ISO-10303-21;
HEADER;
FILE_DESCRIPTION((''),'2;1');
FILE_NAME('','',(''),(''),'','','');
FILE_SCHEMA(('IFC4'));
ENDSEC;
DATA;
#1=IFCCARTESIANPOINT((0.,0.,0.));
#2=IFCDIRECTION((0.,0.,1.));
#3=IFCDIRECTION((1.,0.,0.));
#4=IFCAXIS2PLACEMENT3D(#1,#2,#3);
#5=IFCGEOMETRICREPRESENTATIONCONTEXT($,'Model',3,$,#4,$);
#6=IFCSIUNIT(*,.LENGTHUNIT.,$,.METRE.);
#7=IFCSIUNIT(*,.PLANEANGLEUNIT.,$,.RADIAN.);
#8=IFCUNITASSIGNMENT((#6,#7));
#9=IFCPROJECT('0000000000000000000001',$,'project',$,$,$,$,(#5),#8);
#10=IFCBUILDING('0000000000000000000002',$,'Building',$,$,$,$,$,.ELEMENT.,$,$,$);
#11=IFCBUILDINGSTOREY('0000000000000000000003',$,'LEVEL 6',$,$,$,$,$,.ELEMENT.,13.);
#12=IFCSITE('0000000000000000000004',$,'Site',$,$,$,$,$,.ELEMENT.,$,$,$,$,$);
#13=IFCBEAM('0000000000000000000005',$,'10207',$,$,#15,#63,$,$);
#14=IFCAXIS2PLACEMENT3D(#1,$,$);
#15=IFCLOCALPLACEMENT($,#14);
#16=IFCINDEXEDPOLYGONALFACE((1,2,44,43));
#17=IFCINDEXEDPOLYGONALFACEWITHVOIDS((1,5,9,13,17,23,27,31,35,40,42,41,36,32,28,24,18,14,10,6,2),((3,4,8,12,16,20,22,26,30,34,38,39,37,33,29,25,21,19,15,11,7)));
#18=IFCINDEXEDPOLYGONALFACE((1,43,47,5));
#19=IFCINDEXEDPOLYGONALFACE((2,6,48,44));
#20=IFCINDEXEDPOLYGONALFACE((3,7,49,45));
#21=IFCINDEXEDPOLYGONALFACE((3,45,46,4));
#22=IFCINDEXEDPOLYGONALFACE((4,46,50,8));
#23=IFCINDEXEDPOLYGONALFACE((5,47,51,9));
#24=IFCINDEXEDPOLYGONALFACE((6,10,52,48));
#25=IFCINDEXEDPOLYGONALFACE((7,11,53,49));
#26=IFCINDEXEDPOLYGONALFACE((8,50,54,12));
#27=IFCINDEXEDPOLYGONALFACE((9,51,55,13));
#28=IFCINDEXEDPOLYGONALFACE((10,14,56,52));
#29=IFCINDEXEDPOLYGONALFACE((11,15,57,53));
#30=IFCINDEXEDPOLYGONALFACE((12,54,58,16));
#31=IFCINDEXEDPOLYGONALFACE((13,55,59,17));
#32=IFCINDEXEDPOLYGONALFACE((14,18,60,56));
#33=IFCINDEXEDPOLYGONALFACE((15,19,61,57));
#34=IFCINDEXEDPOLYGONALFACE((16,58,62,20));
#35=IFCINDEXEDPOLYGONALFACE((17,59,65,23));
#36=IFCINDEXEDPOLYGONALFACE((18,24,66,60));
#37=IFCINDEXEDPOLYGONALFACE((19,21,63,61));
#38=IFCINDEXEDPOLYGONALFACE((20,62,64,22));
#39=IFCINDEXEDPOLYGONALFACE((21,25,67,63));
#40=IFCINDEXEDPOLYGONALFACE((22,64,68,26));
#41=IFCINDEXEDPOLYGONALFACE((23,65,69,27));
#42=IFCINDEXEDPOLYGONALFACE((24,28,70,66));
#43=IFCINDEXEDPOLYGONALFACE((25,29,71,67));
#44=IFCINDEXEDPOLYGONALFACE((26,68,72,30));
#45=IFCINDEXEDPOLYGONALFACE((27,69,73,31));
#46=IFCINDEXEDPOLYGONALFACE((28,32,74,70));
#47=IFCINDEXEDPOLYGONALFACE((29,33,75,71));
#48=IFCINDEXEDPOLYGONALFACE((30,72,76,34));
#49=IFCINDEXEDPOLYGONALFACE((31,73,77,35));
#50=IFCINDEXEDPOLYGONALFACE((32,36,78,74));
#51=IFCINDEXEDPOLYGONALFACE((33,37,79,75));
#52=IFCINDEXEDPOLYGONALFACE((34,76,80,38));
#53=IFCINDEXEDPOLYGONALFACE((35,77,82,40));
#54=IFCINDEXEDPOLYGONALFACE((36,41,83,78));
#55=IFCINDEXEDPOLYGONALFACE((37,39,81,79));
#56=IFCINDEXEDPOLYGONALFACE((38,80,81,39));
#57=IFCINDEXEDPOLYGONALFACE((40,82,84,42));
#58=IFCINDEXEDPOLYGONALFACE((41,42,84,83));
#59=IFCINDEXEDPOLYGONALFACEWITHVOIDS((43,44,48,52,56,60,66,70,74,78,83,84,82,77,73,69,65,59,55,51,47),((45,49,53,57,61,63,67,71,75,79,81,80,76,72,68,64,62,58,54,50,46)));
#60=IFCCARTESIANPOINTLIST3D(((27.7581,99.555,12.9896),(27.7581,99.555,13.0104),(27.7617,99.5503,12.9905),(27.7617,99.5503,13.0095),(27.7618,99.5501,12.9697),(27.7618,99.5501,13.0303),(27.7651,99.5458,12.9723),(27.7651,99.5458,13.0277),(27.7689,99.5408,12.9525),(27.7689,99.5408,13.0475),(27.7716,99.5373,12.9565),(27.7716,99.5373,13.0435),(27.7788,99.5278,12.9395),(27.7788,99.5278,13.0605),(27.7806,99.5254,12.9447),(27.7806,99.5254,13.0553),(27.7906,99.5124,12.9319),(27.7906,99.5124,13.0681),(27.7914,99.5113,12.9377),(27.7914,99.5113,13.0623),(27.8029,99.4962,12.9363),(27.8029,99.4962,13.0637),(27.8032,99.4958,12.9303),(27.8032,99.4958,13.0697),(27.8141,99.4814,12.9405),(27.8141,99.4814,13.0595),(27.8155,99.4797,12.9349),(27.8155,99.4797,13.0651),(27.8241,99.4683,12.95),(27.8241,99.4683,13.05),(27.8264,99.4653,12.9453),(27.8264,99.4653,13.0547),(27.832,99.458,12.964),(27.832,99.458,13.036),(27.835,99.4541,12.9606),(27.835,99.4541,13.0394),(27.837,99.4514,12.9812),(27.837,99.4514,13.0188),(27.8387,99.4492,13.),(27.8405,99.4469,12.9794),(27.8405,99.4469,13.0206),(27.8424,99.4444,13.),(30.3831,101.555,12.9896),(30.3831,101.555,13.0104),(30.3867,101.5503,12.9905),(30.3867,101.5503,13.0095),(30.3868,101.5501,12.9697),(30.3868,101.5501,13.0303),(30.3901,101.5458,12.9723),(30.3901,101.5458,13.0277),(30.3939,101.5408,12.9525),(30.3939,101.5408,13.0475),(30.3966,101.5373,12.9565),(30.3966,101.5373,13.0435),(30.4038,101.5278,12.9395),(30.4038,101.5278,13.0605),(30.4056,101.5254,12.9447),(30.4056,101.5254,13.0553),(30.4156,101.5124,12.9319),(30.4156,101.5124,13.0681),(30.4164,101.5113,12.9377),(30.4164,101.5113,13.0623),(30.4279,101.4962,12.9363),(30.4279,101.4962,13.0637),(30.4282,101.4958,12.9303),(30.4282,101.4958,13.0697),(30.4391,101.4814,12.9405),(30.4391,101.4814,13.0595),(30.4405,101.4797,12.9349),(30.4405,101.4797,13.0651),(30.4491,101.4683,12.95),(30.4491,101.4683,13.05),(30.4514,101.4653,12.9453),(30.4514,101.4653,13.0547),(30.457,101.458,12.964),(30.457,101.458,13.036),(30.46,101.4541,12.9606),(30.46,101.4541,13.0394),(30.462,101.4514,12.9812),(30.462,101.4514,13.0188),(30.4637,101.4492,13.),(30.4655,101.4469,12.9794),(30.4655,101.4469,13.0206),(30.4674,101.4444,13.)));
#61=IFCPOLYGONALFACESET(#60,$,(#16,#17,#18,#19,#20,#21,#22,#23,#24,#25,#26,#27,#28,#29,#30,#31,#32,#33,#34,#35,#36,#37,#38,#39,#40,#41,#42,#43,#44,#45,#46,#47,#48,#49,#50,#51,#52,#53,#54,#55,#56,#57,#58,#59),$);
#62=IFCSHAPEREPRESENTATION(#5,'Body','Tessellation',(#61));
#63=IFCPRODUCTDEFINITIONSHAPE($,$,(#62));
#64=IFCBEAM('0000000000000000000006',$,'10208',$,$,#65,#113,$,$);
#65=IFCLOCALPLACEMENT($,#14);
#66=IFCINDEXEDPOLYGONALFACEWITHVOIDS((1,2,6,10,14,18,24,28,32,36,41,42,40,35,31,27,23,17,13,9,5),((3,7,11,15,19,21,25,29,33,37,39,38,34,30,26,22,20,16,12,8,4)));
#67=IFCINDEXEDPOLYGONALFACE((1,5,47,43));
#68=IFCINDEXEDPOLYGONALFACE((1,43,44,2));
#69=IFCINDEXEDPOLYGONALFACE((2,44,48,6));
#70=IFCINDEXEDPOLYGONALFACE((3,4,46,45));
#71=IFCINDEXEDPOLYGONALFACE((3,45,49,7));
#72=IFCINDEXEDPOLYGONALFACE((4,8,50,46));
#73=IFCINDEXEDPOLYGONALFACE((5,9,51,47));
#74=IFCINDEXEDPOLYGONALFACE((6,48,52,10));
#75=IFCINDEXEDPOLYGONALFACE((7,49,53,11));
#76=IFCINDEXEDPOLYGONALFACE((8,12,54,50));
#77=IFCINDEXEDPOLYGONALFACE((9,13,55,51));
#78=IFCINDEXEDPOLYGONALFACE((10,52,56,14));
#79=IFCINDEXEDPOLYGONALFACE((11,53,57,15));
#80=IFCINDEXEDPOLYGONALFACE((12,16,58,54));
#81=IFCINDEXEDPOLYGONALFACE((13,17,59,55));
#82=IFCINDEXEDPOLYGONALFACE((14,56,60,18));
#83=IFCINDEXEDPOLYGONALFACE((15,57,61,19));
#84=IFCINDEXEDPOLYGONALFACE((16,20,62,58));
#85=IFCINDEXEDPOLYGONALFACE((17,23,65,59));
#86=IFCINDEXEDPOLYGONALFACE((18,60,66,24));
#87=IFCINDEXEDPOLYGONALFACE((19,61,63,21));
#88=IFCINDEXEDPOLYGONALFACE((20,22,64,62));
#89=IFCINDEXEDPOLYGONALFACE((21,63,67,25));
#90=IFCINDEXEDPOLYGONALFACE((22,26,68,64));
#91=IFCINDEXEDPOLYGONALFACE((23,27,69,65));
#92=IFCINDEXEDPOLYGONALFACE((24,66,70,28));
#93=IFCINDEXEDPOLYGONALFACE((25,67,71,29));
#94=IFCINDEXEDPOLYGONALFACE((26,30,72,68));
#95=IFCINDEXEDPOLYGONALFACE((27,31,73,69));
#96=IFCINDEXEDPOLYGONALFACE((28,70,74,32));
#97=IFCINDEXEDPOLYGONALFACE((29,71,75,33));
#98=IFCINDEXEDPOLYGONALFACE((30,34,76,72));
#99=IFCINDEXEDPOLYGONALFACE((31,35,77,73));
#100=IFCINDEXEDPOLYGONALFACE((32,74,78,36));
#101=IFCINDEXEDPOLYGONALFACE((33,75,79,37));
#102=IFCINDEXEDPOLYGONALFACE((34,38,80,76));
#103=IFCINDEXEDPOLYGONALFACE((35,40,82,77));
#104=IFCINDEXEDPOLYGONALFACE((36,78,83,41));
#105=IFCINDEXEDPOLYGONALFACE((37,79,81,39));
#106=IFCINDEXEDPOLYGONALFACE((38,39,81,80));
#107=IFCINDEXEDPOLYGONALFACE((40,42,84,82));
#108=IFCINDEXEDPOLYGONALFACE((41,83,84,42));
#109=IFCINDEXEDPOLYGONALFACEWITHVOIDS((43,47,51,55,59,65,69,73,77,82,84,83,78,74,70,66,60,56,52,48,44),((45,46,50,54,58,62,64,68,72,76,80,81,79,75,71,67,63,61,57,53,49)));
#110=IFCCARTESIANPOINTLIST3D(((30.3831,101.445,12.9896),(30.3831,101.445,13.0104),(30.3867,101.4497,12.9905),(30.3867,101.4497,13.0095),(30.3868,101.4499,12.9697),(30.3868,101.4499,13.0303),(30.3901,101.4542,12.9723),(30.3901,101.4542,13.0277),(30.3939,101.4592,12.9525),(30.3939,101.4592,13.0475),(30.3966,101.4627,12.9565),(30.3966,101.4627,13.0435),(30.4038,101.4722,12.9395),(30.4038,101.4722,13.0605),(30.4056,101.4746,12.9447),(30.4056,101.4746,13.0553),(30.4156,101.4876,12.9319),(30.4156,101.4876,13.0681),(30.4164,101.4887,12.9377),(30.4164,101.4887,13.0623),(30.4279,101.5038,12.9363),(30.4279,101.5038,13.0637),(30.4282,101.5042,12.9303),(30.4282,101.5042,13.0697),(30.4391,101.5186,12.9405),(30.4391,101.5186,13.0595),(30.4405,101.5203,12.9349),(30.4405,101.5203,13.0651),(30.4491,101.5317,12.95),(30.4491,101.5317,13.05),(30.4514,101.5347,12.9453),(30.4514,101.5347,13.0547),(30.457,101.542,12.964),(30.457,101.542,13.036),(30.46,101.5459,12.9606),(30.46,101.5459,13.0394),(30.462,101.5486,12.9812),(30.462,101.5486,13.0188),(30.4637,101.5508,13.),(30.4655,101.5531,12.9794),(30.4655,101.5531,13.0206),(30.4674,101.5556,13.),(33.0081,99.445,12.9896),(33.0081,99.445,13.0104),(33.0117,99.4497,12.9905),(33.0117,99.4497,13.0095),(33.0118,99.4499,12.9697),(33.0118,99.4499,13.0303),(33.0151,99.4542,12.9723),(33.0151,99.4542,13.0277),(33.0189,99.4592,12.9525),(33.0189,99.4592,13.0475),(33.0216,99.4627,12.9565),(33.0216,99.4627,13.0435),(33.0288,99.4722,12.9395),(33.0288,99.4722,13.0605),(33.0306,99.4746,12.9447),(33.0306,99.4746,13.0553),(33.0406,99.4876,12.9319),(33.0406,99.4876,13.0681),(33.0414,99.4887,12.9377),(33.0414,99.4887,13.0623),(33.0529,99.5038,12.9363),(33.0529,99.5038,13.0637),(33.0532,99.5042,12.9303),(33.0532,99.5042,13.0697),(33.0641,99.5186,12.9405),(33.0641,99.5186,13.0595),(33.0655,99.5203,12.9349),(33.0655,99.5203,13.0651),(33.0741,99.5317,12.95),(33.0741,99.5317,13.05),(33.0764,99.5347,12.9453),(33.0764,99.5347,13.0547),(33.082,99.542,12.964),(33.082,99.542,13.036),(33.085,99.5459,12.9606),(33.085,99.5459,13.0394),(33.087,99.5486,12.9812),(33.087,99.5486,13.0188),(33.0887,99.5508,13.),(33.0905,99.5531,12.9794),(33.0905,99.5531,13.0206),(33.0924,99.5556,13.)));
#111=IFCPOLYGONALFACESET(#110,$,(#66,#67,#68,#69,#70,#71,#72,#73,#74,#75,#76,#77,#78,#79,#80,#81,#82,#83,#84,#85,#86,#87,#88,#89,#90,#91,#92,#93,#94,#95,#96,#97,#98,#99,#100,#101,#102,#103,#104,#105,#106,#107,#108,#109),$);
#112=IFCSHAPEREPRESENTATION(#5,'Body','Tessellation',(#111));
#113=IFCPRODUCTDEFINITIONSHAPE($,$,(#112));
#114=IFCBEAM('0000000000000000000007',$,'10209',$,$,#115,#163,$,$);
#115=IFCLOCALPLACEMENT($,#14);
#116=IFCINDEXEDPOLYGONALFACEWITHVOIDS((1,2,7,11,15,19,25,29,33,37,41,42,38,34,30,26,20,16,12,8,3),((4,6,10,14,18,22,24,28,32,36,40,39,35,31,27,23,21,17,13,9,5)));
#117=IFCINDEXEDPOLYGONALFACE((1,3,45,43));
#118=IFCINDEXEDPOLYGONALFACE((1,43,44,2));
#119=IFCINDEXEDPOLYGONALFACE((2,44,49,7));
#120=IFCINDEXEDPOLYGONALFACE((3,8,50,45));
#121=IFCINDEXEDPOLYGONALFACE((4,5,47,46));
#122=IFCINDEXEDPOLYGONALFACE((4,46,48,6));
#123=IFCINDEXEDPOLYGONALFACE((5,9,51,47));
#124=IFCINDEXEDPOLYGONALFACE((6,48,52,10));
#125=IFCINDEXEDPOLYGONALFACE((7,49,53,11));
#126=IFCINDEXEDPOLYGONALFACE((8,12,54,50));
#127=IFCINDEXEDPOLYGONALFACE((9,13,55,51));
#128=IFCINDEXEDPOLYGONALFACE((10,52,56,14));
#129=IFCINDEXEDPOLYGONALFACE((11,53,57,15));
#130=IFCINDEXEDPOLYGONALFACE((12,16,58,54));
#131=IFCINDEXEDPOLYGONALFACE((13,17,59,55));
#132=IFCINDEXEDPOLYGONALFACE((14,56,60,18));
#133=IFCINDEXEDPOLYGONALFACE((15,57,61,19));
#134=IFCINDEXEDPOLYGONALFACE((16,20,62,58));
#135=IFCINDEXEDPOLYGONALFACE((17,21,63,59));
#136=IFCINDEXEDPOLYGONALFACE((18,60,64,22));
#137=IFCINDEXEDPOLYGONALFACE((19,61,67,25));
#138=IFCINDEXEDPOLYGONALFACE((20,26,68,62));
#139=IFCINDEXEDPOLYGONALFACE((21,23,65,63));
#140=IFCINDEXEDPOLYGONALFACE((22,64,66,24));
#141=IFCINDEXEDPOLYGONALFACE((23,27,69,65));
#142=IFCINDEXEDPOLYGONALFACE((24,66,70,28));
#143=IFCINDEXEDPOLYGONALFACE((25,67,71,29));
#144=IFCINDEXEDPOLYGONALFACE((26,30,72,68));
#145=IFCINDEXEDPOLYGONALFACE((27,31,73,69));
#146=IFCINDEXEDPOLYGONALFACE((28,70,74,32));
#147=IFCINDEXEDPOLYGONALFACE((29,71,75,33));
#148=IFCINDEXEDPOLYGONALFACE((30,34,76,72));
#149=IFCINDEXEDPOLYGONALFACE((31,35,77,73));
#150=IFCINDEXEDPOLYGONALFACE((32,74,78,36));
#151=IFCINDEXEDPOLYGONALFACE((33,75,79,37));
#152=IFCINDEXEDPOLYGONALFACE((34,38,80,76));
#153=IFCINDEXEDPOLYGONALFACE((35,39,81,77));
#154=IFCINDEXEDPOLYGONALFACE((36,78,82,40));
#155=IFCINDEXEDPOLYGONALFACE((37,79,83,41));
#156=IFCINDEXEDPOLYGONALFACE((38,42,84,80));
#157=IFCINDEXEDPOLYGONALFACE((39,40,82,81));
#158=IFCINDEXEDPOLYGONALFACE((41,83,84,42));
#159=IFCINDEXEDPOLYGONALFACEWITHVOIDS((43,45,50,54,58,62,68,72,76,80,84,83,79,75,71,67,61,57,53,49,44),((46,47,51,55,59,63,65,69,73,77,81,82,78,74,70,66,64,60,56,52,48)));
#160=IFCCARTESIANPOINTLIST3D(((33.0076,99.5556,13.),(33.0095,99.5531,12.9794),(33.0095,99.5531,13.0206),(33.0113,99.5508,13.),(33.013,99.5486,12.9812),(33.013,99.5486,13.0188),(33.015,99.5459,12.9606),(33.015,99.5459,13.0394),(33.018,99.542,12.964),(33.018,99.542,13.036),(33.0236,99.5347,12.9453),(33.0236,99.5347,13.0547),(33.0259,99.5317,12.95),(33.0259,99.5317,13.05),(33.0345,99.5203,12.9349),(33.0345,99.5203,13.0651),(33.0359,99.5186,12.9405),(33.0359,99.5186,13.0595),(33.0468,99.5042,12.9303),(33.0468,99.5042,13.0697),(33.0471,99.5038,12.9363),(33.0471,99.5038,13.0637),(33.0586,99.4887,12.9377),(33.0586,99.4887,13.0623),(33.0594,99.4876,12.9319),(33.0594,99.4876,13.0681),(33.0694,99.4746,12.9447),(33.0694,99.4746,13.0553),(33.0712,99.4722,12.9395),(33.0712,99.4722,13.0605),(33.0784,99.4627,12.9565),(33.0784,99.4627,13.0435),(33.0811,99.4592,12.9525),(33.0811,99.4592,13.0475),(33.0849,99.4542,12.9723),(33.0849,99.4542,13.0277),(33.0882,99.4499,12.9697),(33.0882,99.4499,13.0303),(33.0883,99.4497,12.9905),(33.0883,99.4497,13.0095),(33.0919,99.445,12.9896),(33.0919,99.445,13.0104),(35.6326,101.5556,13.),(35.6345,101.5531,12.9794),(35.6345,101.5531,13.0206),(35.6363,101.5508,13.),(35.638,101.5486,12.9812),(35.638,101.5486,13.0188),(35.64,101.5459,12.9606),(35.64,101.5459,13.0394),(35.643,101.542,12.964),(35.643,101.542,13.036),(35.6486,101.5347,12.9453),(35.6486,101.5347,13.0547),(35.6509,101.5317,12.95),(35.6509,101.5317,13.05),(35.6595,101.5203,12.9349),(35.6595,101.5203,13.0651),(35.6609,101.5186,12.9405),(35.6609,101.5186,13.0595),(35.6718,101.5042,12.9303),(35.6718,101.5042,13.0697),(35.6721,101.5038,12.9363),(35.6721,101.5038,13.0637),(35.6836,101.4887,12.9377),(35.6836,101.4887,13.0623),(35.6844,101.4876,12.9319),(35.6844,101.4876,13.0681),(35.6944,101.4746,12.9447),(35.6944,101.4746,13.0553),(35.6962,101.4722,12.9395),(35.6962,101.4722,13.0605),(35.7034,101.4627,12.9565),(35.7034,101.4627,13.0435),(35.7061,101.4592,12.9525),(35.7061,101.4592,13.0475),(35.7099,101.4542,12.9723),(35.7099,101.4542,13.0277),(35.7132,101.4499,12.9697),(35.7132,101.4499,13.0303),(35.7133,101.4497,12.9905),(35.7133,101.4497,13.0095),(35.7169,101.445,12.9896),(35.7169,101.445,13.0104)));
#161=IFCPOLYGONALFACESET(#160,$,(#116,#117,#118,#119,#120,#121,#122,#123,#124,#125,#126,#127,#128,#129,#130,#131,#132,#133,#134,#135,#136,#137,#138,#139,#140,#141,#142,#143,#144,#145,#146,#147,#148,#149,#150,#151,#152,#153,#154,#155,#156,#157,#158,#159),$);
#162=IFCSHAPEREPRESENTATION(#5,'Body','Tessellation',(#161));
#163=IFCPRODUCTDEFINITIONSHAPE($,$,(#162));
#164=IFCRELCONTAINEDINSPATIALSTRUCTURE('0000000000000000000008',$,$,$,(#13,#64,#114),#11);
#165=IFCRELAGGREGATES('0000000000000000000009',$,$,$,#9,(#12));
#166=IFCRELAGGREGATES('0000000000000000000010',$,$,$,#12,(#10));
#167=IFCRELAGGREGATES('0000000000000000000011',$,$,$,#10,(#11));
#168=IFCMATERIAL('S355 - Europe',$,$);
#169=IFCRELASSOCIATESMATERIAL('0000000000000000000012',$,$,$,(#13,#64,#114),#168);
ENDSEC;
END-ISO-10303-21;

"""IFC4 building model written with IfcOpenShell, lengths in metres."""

from ifc_helpers import new_model, si_unit, frame, origin_with_axes, origin_2d_with_axis, place, context, project, spatial, hollow_circle, extrude, material, material_profile, profile_set, profile_usage, element, save


model = new_model("IFC4")

# Units and contexts
model_context = context("Model", 3, world=origin_with_axes())
ifc_project = project(units=[si_unit("LENGTHUNIT", "METRE"), si_unit("PLANEANGLEUNIT", "RADIAN")], contexts=[model_context])

# Site, building, storey
site = spatial("IfcSite", under=ifc_project, Name="Site", CompositionType="ELEMENT")
building = spatial("IfcBuilding", under=site, Name="Building", CompositionType="ELEMENT")
storey = spatial("IfcBuildingStorey", under=building, Name="LEVEL 6", CompositionType="ELEMENT", Elevation=13.0)

# Shared definitions
ifc_material = material(Name="S355 - Europe")

# Beams
ifc_material_profile_1 = material_profile(ifc_material, hollow_circle(Radius=0.0699, WallThickness=0.006, at=origin_2d_with_axis()))
ifc_profile_set_1 = profile_set([ifc_material_profile_1])
ifc_profile_usage_1 = profile_usage(ifc_profile_set_1, cardinal=10)
beam_1_placement = place(None, frame((30.425, 101.5, 13.0), z_axis=(-0.795432, -0.606043, 0.0), x_axis=(0.606043, -0.795432, 0.0)))
element("IfcBeam", 1, at=beam_1_placement, inside=storey, material=ifc_profile_usage_1, Name="10207", context=model_context, shape_type="SweptSolid", body=[
    extrude(hollow_circle(Radius=0.0699, WallThickness=0.006, at=origin_2d_with_axis()), origin_with_axes(), (0.0, 0.0, 1.0), 3.3001),
])
ifc_material_profile_2 = material_profile(ifc_material, hollow_circle(Radius=0.0699, WallThickness=0.006, at=origin_2d_with_axis()))
ifc_profile_set_2 = profile_set([ifc_material_profile_2])
ifc_profile_usage_2 = profile_usage(ifc_profile_set_2, cardinal=10)
beam_2_placement = place(None, frame((30.425, 101.5, 13.0), z_axis=(0.795432, -0.606043, 0.0), x_axis=(0.606043, 0.795432, 0.0)))
element("IfcBeam", 2, at=beam_2_placement, inside=storey, material=ifc_profile_usage_2, Name="10208", context=model_context, shape_type="SweptSolid", body=[
    extrude(hollow_circle(Radius=0.0699, WallThickness=0.006, at=origin_2d_with_axis()), origin_with_axes(), (0.0, 0.0, 1.0), 3.3001),
])
ifc_material_profile_3 = material_profile(ifc_material, hollow_circle(Radius=0.0699, WallThickness=0.006, at=origin_2d_with_axis()))
ifc_profile_set_3 = profile_set([ifc_material_profile_3])
ifc_profile_usage_3 = profile_usage(ifc_profile_set_3, cardinal=10)
beam_3_placement = place(None, frame((33.05, 99.5, 13.0), z_axis=(0.795432, 0.606043, 0.0), x_axis=(-0.606043, 0.795432, 0.0)))
element("IfcBeam", 3, at=beam_3_placement, inside=storey, material=ifc_profile_usage_3, Name="10209", context=model_context, shape_type="SweptSolid", body=[
    extrude(hollow_circle(Radius=0.0699, WallThickness=0.006, at=origin_2d_with_axis()), origin_with_axes(), (0.0, 0.0, 1.0), 3.3001),
])

save(model, "model.ifc")
